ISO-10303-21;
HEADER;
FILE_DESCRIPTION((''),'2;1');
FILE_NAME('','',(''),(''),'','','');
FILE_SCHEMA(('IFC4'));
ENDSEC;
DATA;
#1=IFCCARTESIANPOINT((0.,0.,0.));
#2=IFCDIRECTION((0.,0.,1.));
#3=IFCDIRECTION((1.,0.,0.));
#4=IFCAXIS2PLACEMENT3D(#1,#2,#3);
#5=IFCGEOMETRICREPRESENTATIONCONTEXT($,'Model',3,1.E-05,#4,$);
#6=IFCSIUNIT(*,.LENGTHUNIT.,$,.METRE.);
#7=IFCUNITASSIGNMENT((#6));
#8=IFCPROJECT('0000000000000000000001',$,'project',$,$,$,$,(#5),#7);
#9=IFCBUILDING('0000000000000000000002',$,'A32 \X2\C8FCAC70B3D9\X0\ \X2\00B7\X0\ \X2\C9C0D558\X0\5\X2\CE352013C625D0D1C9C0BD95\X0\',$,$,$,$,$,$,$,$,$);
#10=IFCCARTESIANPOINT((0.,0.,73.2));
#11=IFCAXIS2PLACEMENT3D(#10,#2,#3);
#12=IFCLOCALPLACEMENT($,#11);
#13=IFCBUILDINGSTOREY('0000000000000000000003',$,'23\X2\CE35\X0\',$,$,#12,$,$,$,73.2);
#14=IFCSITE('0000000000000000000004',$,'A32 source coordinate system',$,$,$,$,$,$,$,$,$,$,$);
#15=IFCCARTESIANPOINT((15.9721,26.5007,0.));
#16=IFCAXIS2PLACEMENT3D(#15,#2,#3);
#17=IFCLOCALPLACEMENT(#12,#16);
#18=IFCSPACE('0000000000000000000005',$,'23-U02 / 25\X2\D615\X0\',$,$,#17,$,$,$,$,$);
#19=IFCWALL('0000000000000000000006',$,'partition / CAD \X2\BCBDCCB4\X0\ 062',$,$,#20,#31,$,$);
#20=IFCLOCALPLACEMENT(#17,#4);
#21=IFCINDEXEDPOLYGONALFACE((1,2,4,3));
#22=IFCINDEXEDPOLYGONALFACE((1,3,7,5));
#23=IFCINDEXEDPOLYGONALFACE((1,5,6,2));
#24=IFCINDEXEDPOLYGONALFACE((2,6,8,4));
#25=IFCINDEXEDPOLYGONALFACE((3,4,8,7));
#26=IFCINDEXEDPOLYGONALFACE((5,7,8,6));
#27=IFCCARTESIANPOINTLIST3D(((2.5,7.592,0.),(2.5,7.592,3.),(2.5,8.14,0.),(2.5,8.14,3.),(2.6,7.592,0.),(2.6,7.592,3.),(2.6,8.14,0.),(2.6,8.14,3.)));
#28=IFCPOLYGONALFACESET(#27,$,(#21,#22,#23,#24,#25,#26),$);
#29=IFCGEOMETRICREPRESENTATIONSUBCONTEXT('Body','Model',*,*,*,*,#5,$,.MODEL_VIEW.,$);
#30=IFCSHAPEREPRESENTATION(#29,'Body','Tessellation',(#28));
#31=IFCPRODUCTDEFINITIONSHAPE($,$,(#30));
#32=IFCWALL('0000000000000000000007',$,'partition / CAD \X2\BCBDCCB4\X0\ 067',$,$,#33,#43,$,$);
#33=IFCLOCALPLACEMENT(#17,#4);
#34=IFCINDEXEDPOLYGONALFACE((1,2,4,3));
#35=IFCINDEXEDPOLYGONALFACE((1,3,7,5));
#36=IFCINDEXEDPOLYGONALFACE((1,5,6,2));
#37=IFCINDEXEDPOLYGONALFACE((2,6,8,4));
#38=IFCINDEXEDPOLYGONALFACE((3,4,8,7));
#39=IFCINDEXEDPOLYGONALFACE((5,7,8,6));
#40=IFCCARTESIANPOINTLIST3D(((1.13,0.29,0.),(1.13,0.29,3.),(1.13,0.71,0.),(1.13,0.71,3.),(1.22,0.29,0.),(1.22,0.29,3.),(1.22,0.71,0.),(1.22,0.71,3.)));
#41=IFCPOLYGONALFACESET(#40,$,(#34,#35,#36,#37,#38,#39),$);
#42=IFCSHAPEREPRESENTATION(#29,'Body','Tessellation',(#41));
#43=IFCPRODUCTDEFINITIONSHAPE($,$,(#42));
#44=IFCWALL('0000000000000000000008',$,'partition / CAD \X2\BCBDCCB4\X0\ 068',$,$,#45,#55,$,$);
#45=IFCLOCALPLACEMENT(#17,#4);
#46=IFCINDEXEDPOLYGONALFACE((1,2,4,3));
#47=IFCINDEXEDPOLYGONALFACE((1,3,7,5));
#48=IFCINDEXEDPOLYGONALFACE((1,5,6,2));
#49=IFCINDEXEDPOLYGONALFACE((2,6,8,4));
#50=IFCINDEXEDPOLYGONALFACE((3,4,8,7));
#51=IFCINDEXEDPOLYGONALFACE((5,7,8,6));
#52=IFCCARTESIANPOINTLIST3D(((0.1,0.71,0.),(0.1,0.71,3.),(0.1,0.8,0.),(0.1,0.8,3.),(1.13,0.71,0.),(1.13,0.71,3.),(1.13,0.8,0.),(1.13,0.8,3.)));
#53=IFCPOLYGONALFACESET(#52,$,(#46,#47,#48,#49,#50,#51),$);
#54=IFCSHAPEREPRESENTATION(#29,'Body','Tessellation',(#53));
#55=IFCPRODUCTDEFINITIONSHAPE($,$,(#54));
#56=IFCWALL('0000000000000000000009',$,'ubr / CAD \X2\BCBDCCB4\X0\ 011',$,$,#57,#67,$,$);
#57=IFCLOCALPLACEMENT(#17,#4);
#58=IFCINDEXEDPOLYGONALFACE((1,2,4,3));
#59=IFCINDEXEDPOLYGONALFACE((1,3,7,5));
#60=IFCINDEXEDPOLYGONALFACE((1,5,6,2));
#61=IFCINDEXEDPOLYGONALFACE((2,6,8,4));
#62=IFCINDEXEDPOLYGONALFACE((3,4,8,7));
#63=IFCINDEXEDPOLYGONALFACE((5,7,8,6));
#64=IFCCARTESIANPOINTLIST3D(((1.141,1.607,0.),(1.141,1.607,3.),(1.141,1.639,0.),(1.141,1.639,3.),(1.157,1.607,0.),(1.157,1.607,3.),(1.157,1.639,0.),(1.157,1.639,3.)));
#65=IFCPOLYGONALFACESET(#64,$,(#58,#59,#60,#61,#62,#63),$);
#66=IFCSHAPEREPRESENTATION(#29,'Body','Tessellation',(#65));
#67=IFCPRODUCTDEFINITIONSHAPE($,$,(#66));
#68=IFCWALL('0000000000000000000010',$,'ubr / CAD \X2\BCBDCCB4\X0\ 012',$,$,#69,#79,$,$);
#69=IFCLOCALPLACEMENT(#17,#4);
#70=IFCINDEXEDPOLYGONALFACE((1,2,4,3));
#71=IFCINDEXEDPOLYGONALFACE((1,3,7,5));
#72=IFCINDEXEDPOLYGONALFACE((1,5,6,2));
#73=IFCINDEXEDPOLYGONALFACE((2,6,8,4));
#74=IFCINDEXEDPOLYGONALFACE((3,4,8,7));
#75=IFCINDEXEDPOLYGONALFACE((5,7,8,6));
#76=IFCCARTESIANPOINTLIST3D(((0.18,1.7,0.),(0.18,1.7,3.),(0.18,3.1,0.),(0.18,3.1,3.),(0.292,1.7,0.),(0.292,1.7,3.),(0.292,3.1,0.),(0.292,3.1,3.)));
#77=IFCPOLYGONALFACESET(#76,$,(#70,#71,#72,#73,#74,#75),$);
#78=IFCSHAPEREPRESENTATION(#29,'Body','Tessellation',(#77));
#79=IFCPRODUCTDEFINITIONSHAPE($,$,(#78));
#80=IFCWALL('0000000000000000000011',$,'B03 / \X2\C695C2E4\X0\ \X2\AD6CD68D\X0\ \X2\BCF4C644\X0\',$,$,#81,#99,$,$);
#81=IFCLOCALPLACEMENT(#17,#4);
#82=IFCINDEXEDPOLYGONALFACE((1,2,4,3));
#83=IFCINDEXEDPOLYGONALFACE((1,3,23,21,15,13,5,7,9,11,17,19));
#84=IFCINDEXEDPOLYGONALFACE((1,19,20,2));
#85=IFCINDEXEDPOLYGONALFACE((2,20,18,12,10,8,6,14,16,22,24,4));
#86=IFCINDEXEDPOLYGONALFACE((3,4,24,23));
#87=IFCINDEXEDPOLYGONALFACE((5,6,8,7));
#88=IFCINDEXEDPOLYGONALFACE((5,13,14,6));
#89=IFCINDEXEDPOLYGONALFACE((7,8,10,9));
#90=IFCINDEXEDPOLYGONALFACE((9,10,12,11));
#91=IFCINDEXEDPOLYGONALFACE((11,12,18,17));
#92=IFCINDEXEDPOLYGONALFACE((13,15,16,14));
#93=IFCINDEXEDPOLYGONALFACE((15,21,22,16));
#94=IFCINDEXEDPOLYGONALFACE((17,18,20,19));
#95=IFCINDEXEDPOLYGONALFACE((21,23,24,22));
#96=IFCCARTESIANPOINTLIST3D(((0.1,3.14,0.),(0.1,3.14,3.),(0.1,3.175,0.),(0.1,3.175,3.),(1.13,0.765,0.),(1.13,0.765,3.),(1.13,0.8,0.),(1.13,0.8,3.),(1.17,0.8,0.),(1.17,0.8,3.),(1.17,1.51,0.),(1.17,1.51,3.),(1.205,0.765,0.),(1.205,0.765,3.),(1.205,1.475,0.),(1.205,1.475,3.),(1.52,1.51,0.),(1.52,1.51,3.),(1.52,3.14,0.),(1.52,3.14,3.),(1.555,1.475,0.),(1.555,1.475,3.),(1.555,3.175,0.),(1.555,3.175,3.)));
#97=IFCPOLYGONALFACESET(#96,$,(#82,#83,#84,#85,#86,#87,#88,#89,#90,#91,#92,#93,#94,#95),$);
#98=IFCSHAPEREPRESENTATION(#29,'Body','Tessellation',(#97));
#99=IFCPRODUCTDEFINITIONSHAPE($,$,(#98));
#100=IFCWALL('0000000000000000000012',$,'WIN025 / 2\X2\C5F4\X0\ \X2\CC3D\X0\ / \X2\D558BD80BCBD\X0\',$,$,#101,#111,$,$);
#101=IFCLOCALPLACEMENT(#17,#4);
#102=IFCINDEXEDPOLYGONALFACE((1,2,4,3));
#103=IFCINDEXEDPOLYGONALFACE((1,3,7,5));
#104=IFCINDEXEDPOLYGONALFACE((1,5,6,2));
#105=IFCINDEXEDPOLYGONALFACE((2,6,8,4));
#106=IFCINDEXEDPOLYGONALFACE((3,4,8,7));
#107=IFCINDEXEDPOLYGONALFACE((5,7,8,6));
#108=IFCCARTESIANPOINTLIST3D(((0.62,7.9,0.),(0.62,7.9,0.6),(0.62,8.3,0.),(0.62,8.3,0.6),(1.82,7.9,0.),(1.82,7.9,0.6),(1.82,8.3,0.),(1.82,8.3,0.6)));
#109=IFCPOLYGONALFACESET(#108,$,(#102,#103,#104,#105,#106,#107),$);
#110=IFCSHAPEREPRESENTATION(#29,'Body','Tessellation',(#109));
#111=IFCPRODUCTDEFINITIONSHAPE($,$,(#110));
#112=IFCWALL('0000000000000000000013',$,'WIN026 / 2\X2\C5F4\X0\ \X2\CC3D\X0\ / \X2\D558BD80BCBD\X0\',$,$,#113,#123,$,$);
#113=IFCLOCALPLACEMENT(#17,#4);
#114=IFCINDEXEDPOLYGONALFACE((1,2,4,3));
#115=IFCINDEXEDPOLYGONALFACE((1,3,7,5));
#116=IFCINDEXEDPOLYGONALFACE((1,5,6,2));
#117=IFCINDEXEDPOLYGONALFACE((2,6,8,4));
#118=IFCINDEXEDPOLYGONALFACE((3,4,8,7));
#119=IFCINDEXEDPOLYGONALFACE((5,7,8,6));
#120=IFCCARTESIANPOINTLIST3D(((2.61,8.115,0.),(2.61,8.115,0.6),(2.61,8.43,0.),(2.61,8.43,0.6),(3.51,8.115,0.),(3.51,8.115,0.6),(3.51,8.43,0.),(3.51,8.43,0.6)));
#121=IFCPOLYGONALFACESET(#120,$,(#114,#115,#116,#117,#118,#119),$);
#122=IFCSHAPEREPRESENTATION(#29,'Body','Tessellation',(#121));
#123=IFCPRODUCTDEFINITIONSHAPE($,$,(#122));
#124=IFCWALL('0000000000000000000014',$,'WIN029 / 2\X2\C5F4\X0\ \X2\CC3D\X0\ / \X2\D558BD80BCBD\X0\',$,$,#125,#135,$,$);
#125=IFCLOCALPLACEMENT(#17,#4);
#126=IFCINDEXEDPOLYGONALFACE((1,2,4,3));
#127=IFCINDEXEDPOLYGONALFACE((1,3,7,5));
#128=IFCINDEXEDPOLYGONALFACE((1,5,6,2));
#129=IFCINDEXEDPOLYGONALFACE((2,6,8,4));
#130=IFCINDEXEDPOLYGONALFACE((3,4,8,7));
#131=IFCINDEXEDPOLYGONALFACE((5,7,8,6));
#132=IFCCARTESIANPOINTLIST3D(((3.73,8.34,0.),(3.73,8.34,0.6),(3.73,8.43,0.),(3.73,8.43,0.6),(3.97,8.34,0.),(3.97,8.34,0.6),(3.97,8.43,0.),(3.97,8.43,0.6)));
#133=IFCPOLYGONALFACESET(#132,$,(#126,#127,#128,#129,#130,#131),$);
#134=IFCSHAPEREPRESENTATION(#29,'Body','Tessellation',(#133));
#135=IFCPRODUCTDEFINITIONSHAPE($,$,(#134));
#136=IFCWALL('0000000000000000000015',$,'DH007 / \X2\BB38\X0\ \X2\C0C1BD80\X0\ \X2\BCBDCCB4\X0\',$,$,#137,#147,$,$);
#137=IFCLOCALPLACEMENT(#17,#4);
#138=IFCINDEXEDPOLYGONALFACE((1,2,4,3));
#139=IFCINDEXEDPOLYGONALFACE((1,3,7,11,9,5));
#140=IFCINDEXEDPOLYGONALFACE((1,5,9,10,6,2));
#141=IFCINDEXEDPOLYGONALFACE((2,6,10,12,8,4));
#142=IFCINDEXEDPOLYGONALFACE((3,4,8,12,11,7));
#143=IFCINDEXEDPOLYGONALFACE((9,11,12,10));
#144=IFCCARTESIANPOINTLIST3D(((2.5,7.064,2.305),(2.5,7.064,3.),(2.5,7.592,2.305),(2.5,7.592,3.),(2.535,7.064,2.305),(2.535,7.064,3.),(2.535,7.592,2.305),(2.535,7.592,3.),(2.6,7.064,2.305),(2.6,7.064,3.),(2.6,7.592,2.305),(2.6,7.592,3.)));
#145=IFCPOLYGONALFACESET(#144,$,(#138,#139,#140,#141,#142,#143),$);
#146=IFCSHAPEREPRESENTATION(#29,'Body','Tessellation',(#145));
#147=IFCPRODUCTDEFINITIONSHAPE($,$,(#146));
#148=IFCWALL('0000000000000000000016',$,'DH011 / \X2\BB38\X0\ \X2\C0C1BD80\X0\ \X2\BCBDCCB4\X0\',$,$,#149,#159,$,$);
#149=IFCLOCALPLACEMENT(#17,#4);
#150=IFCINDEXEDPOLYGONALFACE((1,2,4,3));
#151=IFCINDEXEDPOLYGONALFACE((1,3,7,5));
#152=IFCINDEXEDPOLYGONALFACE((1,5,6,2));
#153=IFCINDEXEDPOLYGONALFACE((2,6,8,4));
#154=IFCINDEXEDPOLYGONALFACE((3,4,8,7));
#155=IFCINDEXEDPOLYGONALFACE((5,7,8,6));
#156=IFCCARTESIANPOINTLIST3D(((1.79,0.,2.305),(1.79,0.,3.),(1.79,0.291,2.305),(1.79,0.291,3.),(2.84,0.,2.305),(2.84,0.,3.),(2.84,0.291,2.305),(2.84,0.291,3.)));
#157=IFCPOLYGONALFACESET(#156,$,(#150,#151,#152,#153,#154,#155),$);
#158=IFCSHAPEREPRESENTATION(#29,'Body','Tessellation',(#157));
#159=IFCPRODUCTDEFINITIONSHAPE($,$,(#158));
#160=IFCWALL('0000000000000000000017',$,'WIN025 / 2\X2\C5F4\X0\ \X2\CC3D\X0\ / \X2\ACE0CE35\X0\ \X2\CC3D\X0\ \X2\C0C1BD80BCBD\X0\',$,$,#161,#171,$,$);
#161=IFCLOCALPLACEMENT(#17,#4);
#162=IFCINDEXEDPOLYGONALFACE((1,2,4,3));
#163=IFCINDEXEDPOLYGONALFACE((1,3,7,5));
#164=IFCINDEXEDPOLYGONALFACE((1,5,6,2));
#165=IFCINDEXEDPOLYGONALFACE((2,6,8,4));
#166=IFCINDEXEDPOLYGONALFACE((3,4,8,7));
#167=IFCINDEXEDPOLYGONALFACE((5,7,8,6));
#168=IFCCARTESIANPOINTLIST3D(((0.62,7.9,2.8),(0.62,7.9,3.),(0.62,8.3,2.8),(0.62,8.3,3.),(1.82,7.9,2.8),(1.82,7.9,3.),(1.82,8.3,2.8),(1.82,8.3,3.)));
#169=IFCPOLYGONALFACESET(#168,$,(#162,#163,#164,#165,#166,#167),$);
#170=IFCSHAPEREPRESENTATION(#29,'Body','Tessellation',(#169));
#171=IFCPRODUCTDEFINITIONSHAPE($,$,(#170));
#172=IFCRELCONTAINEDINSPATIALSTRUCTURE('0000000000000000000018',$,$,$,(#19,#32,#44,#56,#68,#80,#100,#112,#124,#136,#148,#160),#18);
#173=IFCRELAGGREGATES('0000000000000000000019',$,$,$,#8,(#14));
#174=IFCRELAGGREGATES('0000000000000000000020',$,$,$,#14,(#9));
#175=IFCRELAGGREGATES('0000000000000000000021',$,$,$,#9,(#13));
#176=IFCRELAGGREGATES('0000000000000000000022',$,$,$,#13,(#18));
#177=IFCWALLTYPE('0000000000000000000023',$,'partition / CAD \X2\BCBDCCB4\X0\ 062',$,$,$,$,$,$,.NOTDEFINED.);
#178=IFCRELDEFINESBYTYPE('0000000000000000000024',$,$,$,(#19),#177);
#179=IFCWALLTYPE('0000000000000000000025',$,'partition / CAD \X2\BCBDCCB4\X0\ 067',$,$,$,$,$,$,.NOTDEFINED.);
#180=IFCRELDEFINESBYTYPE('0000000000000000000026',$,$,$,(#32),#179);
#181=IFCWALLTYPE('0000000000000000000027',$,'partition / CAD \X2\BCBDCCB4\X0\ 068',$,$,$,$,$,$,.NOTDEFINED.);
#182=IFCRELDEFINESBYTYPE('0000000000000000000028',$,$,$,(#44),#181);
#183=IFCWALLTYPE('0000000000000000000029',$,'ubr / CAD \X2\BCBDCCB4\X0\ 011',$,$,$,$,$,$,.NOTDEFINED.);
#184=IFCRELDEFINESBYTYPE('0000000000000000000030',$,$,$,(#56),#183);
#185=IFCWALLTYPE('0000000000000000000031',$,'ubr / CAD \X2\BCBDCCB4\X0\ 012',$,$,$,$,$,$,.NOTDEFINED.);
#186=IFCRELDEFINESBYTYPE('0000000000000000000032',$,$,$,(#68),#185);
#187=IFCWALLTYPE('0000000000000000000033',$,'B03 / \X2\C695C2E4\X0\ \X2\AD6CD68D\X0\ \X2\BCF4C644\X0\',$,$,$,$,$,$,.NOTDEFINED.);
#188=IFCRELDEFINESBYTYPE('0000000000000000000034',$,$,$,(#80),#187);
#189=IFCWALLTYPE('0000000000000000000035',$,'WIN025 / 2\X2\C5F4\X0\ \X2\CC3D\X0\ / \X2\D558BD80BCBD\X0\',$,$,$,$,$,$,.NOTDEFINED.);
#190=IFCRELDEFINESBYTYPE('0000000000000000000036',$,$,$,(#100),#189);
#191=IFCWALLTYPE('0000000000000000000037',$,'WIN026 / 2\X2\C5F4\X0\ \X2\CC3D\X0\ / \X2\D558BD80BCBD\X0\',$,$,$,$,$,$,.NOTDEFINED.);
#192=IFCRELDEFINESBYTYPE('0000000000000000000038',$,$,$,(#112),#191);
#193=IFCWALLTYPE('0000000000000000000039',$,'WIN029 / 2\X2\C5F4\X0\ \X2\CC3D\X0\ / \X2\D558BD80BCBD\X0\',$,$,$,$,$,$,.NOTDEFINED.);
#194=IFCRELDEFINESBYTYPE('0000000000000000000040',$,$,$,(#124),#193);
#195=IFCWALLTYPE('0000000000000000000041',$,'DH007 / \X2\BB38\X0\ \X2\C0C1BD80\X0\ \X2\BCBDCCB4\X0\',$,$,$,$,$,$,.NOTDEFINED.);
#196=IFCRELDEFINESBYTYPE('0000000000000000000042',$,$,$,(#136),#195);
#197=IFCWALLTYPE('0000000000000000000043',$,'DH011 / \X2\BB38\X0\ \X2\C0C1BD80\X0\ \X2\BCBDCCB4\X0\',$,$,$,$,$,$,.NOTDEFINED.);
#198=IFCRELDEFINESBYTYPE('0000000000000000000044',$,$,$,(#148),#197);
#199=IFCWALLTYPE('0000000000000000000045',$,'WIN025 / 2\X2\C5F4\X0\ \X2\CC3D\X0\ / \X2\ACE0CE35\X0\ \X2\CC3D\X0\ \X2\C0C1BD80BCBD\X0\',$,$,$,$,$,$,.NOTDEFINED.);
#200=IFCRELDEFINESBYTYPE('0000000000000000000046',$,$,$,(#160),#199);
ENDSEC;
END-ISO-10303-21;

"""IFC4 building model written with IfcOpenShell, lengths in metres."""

from ifc_helpers import new_model, si_unit, frame, origin, origin_with_axes, place, context, subcontext, project, spatial, polyline, outline, extrude, source, transform, mapped, type_object, type_shapes, element, save


model = new_model("IFC4")

# Units and contexts
model_context = context("Model", 3, precision=1e-05, world=origin_with_axes())
body_context = subcontext(model_context, "Body", "Model", "MODEL_VIEW")
ifc_project = project(units=[si_unit("LENGTHUNIT", "METRE")], contexts=[model_context])

# Site, building, storey, space
site = spatial("IfcSite", under=ifc_project, Name="A32 source coordinate system")
building = spatial("IfcBuilding", under=site, Name="A32 주거동 · 지하5층–옥탑지붕")
storey_placement = place(None, frame((0.0, 0.0, 73.2), z_axis=(0.0, 0.0, 1.0), x_axis=(1.0, 0.0, 0.0)))
storey = spatial("IfcBuildingStorey", under=building, at=storey_placement, Name="23층", Elevation=73.2)
space_1_placement = place(storey_placement, frame((15.9721, 26.5007, 0.0), z_axis=(0.0, 0.0, 1.0), x_axis=(1.0, 0.0, 0.0)))
space_1 = spatial("IfcSpace", under=storey, at=space_1_placement, Name="23-U02 / 25형")

# Walls
wall_type_1 = type_object("IfcWallType", Name="partition / CAD 벽체 062", PredefinedType="NOTDEFINED")
shared_shape_1 = source(origin(), body_context, "Body", "SweptSolid", [
    extrude(outline(polyline([(2.5, 7.592), (2.5, 8.14), (2.6, 8.14), (2.6, 7.592), (2.5, 7.592)])), origin(), (0.0, 0.0, 1.0), 3.0),
])
type_shapes(wall_type_1, [shared_shape_1])
wall_1_placement = place(space_1_placement, origin_with_axes())
element("IfcWall", 1, at=wall_1_placement, inside=space_1, type_object=wall_type_1, Name="partition / CAD 벽체 062", context=body_context, shape_type="MappedRepresentation", body=[
    mapped(shared_shape_1, transform((0.0, 0.0, 0.0), scale=1.0)),
])
wall_type_2 = type_object("IfcWallType", Name="partition / CAD 벽체 067", PredefinedType="NOTDEFINED")
shared_shape_2 = source(origin(), body_context, "Body", "SweptSolid", [
    extrude(outline(polyline([(1.22, 0.71), (1.22, 0.29), (1.13, 0.29), (1.13, 0.71), (1.22, 0.71)])), origin(), (0.0, 0.0, 1.0), 3.0),
])
type_shapes(wall_type_2, [shared_shape_2])
wall_2_placement = place(space_1_placement, origin_with_axes())
element("IfcWall", 2, at=wall_2_placement, inside=space_1, type_object=wall_type_2, Name="partition / CAD 벽체 067", context=body_context, shape_type="MappedRepresentation", body=[
    mapped(shared_shape_2, transform((0.0, 0.0, 0.0), scale=1.0)),
])
wall_type_3 = type_object("IfcWallType", Name="partition / CAD 벽체 068", PredefinedType="NOTDEFINED")
shared_shape_3 = source(origin(), body_context, "Body", "SweptSolid", [
    extrude(outline(polyline([(1.13, 0.8), (1.13, 0.71), (0.1, 0.71), (0.1, 0.8), (1.13, 0.8)])), origin(), (0.0, 0.0, 1.0), 3.0),
])
type_shapes(wall_type_3, [shared_shape_3])
wall_3_placement = place(space_1_placement, origin_with_axes())
element("IfcWall", 3, at=wall_3_placement, inside=space_1, type_object=wall_type_3, Name="partition / CAD 벽체 068", context=body_context, shape_type="MappedRepresentation", body=[
    mapped(shared_shape_3, transform((0.0, 0.0, 0.0), scale=1.0)),
])
wall_type_4 = type_object("IfcWallType", Name="ubr / CAD 벽체 011", PredefinedType="NOTDEFINED")
shared_shape_4 = source(origin(), body_context, "Body", "SweptSolid", [
    extrude(outline(polyline([(1.141, 1.607), (1.141, 1.639), (1.157, 1.639), (1.157, 1.607), (1.141, 1.607)])), origin(), (0.0, 0.0, 1.0), 3.0),
])
type_shapes(wall_type_4, [shared_shape_4])
wall_4_placement = place(space_1_placement, origin_with_axes())
element("IfcWall", 4, at=wall_4_placement, inside=space_1, type_object=wall_type_4, Name="ubr / CAD 벽체 011", context=body_context, shape_type="MappedRepresentation", body=[
    mapped(shared_shape_4, transform((0.0, 0.0, 0.0), scale=1.0)),
])
wall_type_5 = type_object("IfcWallType", Name="ubr / CAD 벽체 012", PredefinedType="NOTDEFINED")
shared_shape_5 = source(origin(), body_context, "Body", "SweptSolid", [
    extrude(outline(polyline([(0.18, 1.7), (0.18, 3.1), (0.292, 3.1), (0.292, 1.7), (0.18, 1.7)])), origin(), (0.0, 0.0, 1.0), 3.0),
])
type_shapes(wall_type_5, [shared_shape_5])
wall_5_placement = place(space_1_placement, origin_with_axes())
element("IfcWall", 5, at=wall_5_placement, inside=space_1, type_object=wall_type_5, Name="ubr / CAD 벽체 012", context=body_context, shape_type="MappedRepresentation", body=[
    mapped(shared_shape_5, transform((0.0, 0.0, 0.0), scale=1.0)),
])
wall_type_6 = type_object("IfcWallType", Name="B03 / 욕실 구획 보완", PredefinedType="NOTDEFINED")
shared_shape_6 = source(origin(), body_context, "Body", "SweptSolid", [
    extrude(outline(polyline([(1.13, 0.765), (1.13, 0.8), (1.17, 0.8), (1.17, 1.51), (1.52, 1.51), (1.52, 3.14), (0.1, 3.14), (0.1, 3.175), (1.555, 3.175), (1.555, 1.475), (1.205, 1.475), (1.205, 0.765), (1.13, 0.765)])), origin(), (0.0, 0.0, 1.0), 3.0),
])
type_shapes(wall_type_6, [shared_shape_6])
wall_6_placement = place(space_1_placement, origin_with_axes())
element("IfcWall", 6, at=wall_6_placement, inside=space_1, type_object=wall_type_6, Name="B03 / 욕실 구획 보완", context=body_context, shape_type="MappedRepresentation", body=[
    mapped(shared_shape_6, transform((0.0, 0.0, 0.0), scale=1.0)),
])
wall_type_7 = type_object("IfcWallType", Name="WIN025 / 2열 창 / 하부벽", PredefinedType="NOTDEFINED")
shared_shape_7 = source(origin(), body_context, "Body", "SweptSolid", [
    extrude(outline(polyline([(1.82, 8.3), (1.82, 7.9), (0.62, 7.9), (0.62, 8.3), (1.82, 8.3)])), origin(), (0.0, 0.0, 1.0), 0.6),
])
type_shapes(wall_type_7, [shared_shape_7])
wall_7_placement = place(space_1_placement, origin_with_axes())
element("IfcWall", 7, at=wall_7_placement, inside=space_1, type_object=wall_type_7, Name="WIN025 / 2열 창 / 하부벽", context=body_context, shape_type="MappedRepresentation", body=[
    mapped(shared_shape_7, transform((0.0, 0.0, 0.0), scale=1.0)),
])
wall_type_8 = type_object("IfcWallType", Name="WIN026 / 2열 창 / 하부벽", PredefinedType="NOTDEFINED")
shared_shape_8 = source(origin(), body_context, "Body", "SweptSolid", [
    extrude(outline(polyline([(3.51, 8.43), (3.51, 8.115), (2.61, 8.115), (2.61, 8.43), (3.51, 8.43)])), origin(), (0.0, 0.0, 1.0), 0.6),
])
type_shapes(wall_type_8, [shared_shape_8])
wall_8_placement = place(space_1_placement, origin_with_axes())
element("IfcWall", 8, at=wall_8_placement, inside=space_1, type_object=wall_type_8, Name="WIN026 / 2열 창 / 하부벽", context=body_context, shape_type="MappedRepresentation", body=[
    mapped(shared_shape_8, transform((0.0, 0.0, 0.0), scale=1.0)),
])
wall_type_9 = type_object("IfcWallType", Name="WIN029 / 2열 창 / 하부벽", PredefinedType="NOTDEFINED")
shared_shape_9 = source(origin(), body_context, "Body", "SweptSolid", [
    extrude(outline(polyline([(3.97, 8.43), (3.97, 8.34), (3.73, 8.34), (3.73, 8.43), (3.97, 8.43)])), origin(), (0.0, 0.0, 1.0), 0.6),
])
type_shapes(wall_type_9, [shared_shape_9])
wall_9_placement = place(space_1_placement, origin_with_axes())
element("IfcWall", 9, at=wall_9_placement, inside=space_1, type_object=wall_type_9, Name="WIN029 / 2열 창 / 하부벽", context=body_context, shape_type="MappedRepresentation", body=[
    mapped(shared_shape_9, transform((0.0, 0.0, 0.0), scale=1.0)),
])
wall_type_10 = type_object("IfcWallType", Name="DH007 / 문 상부 벽체", PredefinedType="NOTDEFINED")
shared_shape_10 = source(origin(), body_context, "Body", "SweptSolid", [
    extrude(outline(polyline([(2.5, 7.592), (2.535, 7.592), (2.6, 7.592), (2.6, 7.064), (2.535, 7.064), (2.5, 7.064), (2.5, 7.592)])), frame((0.0, 0.0, 2.305)), (0.0, 0.0, 1.0), 0.695),
])
type_shapes(wall_type_10, [shared_shape_10])
wall_10_placement = place(space_1_placement, origin_with_axes())
element("IfcWall", 10, at=wall_10_placement, inside=space_1, type_object=wall_type_10, Name="DH007 / 문 상부 벽체", context=body_context, shape_type="MappedRepresentation", body=[
    mapped(shared_shape_10, transform((0.0, 0.0, 0.0), scale=1.0)),
])
wall_type_11 = type_object("IfcWallType", Name="DH011 / 문 상부 벽체", PredefinedType="NOTDEFINED")
shared_shape_11 = source(origin(), body_context, "Body", "SweptSolid", [
    extrude(outline(polyline([(2.84, 0.0), (1.79, 0.0), (1.79, 0.291), (2.84, 0.291), (2.84, 0.0)])), frame((0.0, 0.0, 2.305)), (0.0, 0.0, 1.0), 0.695),
])
type_shapes(wall_type_11, [shared_shape_11])
wall_11_placement = place(space_1_placement, origin_with_axes())
element("IfcWall", 11, at=wall_11_placement, inside=space_1, type_object=wall_type_11, Name="DH011 / 문 상부 벽체", context=body_context, shape_type="MappedRepresentation", body=[
    mapped(shared_shape_11, transform((0.0, 0.0, 0.0), scale=1.0)),
])
wall_type_12 = type_object("IfcWallType", Name="WIN025 / 2열 창 / 고층 창 상부벽", PredefinedType="NOTDEFINED")
shared_shape_12 = source(origin(), body_context, "Body", "SweptSolid", [
    extrude(outline(polyline([(1.82, 7.9), (1.82, 8.3), (0.62, 8.3), (0.62, 7.9), (1.82, 7.9)])), frame((0.0, 0.0, 2.8)), (0.0, 0.0, 1.0), 0.2),
])
type_shapes(wall_type_12, [shared_shape_12])
wall_12_placement = place(space_1_placement, origin_with_axes())
element("IfcWall", 12, at=wall_12_placement, inside=space_1, type_object=wall_type_12, Name="WIN025 / 2열 창 / 고층 창 상부벽", context=body_context, shape_type="MappedRepresentation", body=[
    mapped(shared_shape_12, transform((0.0, 0.0, 0.0), scale=1.0)),
])

save(model, "model.ifc")
